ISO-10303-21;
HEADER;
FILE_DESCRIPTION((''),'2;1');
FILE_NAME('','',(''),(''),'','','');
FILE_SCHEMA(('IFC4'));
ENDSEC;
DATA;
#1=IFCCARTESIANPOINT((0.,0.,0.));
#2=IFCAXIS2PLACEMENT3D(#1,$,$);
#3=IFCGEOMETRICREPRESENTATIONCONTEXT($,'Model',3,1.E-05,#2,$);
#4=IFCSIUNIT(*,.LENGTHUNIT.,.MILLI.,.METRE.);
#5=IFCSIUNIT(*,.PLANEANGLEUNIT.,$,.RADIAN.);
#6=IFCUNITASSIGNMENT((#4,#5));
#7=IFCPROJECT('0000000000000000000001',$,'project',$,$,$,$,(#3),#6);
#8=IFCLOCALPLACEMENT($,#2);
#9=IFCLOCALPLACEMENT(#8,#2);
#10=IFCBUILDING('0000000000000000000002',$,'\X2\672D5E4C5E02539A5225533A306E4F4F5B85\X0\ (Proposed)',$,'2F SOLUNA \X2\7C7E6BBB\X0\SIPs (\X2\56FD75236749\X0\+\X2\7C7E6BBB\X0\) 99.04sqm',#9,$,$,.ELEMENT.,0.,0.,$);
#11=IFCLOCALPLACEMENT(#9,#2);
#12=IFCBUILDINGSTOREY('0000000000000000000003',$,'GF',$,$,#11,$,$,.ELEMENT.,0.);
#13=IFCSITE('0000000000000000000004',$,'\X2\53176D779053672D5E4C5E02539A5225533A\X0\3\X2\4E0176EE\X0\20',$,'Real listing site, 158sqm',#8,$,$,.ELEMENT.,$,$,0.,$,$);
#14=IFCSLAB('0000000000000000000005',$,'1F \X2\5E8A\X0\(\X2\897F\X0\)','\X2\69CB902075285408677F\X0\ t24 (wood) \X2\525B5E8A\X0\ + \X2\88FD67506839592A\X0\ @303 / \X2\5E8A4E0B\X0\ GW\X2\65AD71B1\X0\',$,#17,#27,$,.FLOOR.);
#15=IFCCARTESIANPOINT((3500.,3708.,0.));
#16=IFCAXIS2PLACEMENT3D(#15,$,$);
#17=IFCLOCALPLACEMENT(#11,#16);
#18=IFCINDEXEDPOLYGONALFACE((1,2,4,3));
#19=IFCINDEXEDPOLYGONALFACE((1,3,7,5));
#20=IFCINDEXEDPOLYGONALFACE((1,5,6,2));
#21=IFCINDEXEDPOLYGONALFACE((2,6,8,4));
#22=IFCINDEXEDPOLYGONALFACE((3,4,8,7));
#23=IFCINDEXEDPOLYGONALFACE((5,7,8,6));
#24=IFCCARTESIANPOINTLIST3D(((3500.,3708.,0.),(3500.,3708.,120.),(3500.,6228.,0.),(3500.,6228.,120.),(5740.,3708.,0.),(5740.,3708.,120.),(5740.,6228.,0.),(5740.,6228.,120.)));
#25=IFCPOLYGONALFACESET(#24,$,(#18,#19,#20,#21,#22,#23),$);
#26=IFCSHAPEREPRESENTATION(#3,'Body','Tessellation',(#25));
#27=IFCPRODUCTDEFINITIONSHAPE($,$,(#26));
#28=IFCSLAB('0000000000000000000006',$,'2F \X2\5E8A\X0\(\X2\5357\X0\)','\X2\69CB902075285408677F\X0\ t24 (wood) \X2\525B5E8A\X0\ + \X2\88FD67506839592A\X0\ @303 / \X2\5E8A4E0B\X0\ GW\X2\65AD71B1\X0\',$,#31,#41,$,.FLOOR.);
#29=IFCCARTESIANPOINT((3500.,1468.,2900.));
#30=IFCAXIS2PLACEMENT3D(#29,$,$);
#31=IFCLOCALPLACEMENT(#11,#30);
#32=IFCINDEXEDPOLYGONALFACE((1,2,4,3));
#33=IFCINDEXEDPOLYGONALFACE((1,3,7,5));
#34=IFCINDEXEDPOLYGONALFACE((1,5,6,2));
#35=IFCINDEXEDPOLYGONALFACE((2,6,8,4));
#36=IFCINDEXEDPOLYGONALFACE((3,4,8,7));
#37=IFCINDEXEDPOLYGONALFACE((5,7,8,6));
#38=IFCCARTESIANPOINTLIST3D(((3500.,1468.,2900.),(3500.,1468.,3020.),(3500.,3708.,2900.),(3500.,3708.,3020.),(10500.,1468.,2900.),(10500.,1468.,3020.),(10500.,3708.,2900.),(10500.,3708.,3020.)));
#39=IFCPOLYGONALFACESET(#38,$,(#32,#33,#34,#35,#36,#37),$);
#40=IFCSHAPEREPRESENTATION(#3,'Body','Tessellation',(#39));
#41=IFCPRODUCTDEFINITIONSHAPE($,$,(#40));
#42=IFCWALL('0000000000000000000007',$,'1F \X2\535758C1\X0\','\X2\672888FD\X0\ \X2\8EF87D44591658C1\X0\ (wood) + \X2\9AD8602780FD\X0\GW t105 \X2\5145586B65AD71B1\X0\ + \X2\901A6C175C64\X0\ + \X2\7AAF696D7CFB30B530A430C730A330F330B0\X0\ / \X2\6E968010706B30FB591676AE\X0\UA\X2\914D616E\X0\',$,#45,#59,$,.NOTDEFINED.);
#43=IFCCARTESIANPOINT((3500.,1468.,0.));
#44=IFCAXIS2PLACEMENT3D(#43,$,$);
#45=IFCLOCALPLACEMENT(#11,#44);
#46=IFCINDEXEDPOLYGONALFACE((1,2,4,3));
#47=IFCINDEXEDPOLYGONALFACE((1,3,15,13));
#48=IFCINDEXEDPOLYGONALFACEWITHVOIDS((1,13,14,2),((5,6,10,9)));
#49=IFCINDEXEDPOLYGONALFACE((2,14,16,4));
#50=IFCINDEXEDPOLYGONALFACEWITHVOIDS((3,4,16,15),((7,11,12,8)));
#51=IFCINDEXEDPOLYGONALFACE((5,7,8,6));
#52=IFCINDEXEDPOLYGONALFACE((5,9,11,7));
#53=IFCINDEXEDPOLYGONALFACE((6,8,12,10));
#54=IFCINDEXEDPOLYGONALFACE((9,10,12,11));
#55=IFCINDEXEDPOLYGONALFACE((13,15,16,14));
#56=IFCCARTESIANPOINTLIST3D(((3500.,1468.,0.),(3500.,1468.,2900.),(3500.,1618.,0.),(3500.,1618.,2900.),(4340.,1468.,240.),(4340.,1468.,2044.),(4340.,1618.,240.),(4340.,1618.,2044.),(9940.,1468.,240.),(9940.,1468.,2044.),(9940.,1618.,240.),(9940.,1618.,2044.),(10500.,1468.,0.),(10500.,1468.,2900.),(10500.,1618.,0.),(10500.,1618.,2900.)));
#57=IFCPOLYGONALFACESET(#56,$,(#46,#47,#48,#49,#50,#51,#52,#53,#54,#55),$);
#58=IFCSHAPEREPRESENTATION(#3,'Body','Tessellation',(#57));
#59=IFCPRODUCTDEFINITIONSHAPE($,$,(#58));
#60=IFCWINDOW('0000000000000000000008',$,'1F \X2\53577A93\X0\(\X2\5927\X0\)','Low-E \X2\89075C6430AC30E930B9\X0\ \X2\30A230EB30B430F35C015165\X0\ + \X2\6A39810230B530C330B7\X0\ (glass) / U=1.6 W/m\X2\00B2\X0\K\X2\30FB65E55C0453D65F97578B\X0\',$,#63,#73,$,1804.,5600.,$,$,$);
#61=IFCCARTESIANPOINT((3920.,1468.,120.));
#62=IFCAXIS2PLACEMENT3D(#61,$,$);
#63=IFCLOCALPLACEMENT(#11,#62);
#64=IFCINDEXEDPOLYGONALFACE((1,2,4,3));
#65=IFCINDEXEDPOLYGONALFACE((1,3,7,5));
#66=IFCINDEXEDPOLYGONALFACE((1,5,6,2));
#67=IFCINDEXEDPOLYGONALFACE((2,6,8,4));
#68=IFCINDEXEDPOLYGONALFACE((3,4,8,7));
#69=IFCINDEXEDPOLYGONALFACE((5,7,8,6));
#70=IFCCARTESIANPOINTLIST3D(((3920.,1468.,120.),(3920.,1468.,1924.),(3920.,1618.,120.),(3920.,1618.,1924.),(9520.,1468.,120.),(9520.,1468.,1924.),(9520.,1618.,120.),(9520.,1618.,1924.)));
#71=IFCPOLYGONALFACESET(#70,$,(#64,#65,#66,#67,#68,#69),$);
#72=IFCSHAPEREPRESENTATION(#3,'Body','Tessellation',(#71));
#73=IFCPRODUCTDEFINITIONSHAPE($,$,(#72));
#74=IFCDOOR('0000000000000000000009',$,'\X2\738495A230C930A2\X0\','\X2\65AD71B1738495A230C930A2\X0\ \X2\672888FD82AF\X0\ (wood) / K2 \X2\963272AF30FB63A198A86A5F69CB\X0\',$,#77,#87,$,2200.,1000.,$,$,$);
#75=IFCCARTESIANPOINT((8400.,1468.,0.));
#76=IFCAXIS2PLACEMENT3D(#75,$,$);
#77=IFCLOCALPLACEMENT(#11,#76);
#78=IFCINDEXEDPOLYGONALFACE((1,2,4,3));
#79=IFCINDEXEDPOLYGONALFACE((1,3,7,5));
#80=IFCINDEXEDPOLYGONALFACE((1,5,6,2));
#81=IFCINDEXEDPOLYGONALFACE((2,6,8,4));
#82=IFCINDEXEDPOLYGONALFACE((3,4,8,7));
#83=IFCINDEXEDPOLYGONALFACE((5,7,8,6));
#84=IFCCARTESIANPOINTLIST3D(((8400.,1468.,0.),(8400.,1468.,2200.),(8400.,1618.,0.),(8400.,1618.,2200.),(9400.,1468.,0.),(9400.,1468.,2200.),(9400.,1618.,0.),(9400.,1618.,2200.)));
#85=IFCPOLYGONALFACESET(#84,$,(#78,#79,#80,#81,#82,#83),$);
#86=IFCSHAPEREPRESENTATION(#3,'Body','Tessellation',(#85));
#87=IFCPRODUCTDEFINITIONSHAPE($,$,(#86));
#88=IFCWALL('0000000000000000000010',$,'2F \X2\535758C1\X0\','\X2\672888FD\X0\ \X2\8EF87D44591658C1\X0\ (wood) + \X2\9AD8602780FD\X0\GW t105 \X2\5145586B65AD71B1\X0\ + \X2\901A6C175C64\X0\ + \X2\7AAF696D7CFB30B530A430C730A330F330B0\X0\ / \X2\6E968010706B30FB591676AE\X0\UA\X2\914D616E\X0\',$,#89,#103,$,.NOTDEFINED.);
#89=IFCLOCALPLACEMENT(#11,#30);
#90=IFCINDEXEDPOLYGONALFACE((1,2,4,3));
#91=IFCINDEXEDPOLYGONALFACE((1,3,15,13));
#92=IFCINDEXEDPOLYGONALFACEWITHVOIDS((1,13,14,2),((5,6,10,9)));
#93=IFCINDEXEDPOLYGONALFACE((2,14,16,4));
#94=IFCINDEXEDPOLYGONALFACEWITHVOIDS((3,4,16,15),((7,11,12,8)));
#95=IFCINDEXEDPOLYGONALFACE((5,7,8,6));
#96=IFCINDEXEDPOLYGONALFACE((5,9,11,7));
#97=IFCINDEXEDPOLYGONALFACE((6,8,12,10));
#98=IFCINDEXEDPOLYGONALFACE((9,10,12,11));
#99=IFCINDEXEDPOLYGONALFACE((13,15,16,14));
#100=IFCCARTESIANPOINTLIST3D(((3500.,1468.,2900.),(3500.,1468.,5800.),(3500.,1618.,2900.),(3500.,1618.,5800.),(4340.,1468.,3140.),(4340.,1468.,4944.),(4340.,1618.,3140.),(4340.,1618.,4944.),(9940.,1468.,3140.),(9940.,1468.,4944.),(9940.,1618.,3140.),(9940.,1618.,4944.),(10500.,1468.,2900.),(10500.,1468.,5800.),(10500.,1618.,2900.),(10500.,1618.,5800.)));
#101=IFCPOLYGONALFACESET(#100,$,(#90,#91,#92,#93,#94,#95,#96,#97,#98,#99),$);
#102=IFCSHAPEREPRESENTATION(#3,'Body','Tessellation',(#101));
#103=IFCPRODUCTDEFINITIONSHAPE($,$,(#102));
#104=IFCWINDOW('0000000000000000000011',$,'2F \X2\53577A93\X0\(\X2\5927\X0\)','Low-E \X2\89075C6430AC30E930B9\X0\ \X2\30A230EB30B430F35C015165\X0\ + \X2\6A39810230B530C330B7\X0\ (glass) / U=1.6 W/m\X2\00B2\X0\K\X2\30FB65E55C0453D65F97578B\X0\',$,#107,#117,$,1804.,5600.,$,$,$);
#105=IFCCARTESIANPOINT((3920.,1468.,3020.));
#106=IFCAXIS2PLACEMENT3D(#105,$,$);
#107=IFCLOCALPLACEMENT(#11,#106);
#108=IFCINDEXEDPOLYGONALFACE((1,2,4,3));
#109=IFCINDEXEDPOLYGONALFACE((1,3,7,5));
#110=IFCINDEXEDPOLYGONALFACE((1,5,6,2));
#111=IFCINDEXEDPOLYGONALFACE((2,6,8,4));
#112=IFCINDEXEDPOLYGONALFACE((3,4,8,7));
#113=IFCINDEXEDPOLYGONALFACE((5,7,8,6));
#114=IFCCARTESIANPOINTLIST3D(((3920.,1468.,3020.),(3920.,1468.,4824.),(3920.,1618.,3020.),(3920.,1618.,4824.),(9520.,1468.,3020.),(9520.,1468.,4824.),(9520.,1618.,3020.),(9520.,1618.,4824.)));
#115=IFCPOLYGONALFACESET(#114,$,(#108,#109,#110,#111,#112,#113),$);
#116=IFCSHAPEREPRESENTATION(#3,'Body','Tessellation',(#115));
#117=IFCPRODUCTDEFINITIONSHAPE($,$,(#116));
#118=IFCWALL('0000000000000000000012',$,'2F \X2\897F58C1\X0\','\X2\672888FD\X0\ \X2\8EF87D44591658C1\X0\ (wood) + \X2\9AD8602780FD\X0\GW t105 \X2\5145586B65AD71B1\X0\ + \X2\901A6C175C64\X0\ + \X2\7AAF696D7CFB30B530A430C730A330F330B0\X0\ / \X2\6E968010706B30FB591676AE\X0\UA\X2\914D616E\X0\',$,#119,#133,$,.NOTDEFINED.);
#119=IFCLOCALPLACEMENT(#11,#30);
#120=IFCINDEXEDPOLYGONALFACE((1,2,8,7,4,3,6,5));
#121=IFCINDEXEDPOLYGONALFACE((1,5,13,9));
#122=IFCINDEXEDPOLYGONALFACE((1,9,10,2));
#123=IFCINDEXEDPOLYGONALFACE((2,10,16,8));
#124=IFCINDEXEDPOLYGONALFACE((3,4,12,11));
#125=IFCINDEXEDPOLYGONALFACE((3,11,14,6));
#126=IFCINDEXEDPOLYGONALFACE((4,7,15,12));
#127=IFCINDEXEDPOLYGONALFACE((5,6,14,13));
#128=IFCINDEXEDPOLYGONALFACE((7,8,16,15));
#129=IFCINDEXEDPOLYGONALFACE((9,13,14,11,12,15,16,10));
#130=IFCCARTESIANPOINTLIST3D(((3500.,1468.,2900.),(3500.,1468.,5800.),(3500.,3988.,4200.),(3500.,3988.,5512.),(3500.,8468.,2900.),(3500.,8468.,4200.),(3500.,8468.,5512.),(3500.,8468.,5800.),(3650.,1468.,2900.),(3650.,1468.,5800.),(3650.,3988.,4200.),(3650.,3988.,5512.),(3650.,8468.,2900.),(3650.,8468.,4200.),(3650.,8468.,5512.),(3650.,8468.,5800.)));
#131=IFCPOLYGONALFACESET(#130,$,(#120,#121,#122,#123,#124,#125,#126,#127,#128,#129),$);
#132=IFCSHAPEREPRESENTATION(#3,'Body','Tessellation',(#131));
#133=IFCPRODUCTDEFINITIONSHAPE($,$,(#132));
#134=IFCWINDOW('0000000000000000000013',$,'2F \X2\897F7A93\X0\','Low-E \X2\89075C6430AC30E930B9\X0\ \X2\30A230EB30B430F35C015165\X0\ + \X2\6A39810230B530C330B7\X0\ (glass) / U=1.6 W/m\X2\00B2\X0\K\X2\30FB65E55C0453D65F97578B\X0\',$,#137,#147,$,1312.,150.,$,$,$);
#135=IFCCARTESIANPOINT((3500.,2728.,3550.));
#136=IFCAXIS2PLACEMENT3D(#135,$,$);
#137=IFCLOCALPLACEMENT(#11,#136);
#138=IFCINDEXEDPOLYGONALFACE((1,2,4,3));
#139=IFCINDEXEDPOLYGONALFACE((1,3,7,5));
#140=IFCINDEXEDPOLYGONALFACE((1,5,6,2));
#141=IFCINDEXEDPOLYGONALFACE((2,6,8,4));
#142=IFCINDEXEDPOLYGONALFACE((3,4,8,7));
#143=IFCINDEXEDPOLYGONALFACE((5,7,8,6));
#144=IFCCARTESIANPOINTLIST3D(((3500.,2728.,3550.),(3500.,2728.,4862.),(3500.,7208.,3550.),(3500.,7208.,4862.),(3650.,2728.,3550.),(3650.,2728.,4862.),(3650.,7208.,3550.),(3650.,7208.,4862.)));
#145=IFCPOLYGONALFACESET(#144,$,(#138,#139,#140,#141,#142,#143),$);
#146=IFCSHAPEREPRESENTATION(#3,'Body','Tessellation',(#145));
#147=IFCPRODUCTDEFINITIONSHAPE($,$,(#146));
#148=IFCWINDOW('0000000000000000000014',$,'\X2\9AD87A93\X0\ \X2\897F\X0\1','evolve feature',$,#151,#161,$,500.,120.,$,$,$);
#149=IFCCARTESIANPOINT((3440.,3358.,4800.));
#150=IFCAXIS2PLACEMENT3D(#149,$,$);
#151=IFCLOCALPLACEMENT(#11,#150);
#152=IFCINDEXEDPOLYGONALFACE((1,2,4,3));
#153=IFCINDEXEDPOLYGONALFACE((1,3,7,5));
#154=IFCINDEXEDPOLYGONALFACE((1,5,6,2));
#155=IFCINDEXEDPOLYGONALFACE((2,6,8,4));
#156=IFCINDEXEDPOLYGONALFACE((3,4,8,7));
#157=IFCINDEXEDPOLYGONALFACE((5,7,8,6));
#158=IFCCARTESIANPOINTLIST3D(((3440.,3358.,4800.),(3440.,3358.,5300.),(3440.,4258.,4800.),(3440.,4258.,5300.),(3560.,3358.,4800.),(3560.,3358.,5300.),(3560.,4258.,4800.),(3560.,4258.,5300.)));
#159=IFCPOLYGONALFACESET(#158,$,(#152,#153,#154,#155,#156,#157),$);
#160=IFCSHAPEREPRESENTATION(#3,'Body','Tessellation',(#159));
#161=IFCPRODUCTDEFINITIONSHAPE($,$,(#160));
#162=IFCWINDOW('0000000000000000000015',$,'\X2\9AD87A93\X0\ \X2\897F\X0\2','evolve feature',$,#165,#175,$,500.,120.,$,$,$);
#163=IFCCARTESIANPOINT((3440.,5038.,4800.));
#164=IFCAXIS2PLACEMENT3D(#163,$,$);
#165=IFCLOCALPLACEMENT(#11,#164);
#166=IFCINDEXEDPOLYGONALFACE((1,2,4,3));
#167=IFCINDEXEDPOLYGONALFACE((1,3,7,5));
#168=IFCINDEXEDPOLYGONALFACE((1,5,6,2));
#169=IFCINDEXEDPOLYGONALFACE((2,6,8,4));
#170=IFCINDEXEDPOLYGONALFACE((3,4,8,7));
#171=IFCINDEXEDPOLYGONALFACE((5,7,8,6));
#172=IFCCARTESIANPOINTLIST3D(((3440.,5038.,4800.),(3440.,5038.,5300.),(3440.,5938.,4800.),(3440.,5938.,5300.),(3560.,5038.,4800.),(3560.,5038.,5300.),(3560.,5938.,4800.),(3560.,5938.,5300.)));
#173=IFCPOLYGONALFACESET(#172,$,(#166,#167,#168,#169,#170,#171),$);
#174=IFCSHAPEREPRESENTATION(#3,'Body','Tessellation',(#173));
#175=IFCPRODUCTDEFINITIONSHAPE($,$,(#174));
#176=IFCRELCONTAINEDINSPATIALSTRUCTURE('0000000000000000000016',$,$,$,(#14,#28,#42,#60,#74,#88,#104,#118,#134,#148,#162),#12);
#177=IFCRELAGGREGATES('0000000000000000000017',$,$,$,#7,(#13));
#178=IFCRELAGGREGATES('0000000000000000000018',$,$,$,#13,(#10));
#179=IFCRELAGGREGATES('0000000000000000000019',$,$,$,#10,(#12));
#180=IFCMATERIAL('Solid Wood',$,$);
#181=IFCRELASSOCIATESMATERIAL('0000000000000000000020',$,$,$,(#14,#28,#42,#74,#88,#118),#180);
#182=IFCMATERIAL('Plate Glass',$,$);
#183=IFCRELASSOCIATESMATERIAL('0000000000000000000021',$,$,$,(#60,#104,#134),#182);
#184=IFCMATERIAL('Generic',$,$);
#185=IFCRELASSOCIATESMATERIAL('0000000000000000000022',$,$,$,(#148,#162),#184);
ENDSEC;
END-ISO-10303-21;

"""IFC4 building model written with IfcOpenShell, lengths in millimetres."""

from ifc_helpers import new_model, si_unit, frame, frame_2d, origin, place, context, project, spatial, rectangle, extrude, material, element, fill, save


model = new_model("IFC4")

# Units and contexts
model_context = context("Model", 3, precision=1e-05, world=origin())
ifc_project = project(units=[si_unit("LENGTHUNIT", "METRE", prefix="MILLI"), si_unit("PLANEANGLEUNIT", "RADIAN")], contexts=[model_context])

# Site, building, storey
site_placement = place(None, origin())
site = spatial("IfcSite", under=ifc_project, at=site_placement, Name="北海道札幌市厚別区3丁目20", ObjectType="Real listing site, 158sqm", CompositionType="ELEMENT", RefElevation=0.0)
building_placement = place(site_placement, origin())
building = spatial("IfcBuilding", under=site, at=building_placement, Name="札幌市厚別区の住宅 (Proposed)", ObjectType="2F SOLUNA 籾殻SIPs (国産杉+籾殻) 99.04sqm", CompositionType="ELEMENT", ElevationOfRefHeight=0.0, ElevationOfTerrain=0.0)
storey_placement = place(building_placement, origin())
storey = spatial("IfcBuildingStorey", under=building, at=storey_placement, Name="GF", CompositionType="ELEMENT", Elevation=0.0)

# Slabs
ifc_material_1 = material(Name="Solid Wood")
slab_1_placement = place(storey_placement, frame((3500.0, 3708.0, 0.0)))
element("IfcSlab", 1, at=slab_1_placement, inside=storey, material=ifc_material_1, Name="1F 床(西)", Description="構造用合板 t24 (wood) 剛床 + 製材根太 @303 / 床下 GW断熱", PredefinedType="FLOOR", context=model_context, shape_type="SweptSolid", body=[
    extrude(rectangle(XDim=2240.0, YDim=2520.0, at=frame_2d((1120.0, 1260.0))), frame((3500.0, 3708.0, 0.0)), (0.0, 0.0, 1.0), 120.0),
])
slab_2_placement = place(storey_placement, frame((3500.0, 1468.0, 2900.0)))
element("IfcSlab", 2, at=slab_2_placement, inside=storey, material=ifc_material_1, Name="2F 床(南)", Description="構造用合板 t24 (wood) 剛床 + 製材根太 @303 / 床下 GW断熱", PredefinedType="FLOOR", context=model_context, shape_type="SweptSolid", body=[
    extrude(rectangle(XDim=7000.0, YDim=2240.0, at=frame_2d((3500.0, 1120.0))), frame((3500.0, 1468.0, 2900.0)), (0.0, 0.0, 1.0), 120.0),
])
ifc_material_2 = material(Name="Generic")

# Wall, openings, window, door
wall_1_placement = place(storey_placement, frame((3500.0, 1468.0, 0.0)))
wall_1 = element("IfcWall", 3, at=wall_1_placement, inside=storey, material=ifc_material_1, Name="1F 南壁", Description="木製 軸組外壁 (wood) + 高性能GW t105 充填断熱 + 通気層 + 窯業系サイディング / 準耐火・外皮UA配慮", PredefinedType="NOTDEFINED", context=model_context, shape_type="SweptSolid", body=[
    extrude(rectangle(XDim=7000.0, YDim=150.0, at=frame_2d((3500.0, 75.0))), frame((3500.0, 1468.0, 0.0)), (0.0, 0.0, 1.0), 2900.0),
])
opening_1_placement = place(storey_placement, frame((3920.0, 1468.0, 120.0)))
opening_1 = element("IfcOpeningElement", 4, at=opening_1_placement, cuts=wall_1, PredefinedType="NOTDEFINED", context=model_context, shape_type="SweptSolid", body=[
    extrude(rectangle(XDim=5600.0, YDim=150.0, at=frame_2d((2800.0, 75.0))), frame((3920.0, 1468.0, 120.0)), (0.0, 0.0, 1.0), 1804.0),
])
opening_2_placement = place(storey_placement, frame((8400.0, 1468.0, 0.0)))
opening_2 = element("IfcOpeningElement", 5, at=opening_2_placement, cuts=wall_1, PredefinedType="NOTDEFINED", context=model_context, shape_type="SweptSolid", body=[
    extrude(rectangle(XDim=1000.0, YDim=150.0, at=frame_2d((500.0, 75.0))), frame((8400.0, 1468.0, 0.0)), (0.0, 0.0, 1.0), 2200.0),
])
ifc_material_3 = material(Name="Plate Glass")
window_1_placement = place(storey_placement, frame((3920.0, 1468.0, 120.0)))
window_1 = element("IfcWindow", 6, at=window_1_placement, inside=storey, material=ifc_material_3, Name="1F 南窓(大)", Description="Low-E 複層ガラス アルゴン封入 + 樹脂サッシ (glass) / U=1.6 W/m²K・日射取得型", OverallHeight=1804.0, OverallWidth=5600.0, context=model_context, shape_type="SweptSolid", body=[
    extrude(rectangle(XDim=5600.0, YDim=150.0, at=frame_2d((2800.0, 75.0))), frame((3920.0, 1468.0, 120.0)), (0.0, 0.0, 1.0), 1804.0),
])
fill(opening_1, window_1)
door_placement = place(storey_placement, frame((8400.0, 1468.0, 0.0)))
door = element("IfcDoor", 7, at=door_placement, inside=storey, material=ifc_material_1, Name="玄関ドア", Description="断熱玄関ドア 木製芯 (wood) / K2 防犯・採風機構", OverallHeight=2200.0, OverallWidth=1000.0, context=model_context, shape_type="SweptSolid", body=[
    extrude(rectangle(XDim=1000.0, YDim=150.0, at=frame_2d((500.0, 75.0))), frame((8400.0, 1468.0, 0.0)), (0.0, 0.0, 1.0), 2200.0),
])
fill(opening_2, door)

# Wall, opening, window
wall_2_placement = place(storey_placement, frame((3500.0, 1468.0, 2900.0)))
wall_2 = element("IfcWall", 8, at=wall_2_placement, inside=storey, material=ifc_material_1, Name="2F 南壁", Description="木製 軸組外壁 (wood) + 高性能GW t105 充填断熱 + 通気層 + 窯業系サイディング / 準耐火・外皮UA配慮", PredefinedType="NOTDEFINED", context=model_context, shape_type="SweptSolid", body=[
    extrude(rectangle(XDim=7000.0, YDim=150.0, at=frame_2d((3500.0, 75.0))), frame((3500.0, 1468.0, 2900.0)), (0.0, 0.0, 1.0), 2900.0),
])
opening_3_placement = place(storey_placement, frame((3920.0, 1468.0, 3020.0)))
opening_3 = element("IfcOpeningElement", 9, at=opening_3_placement, cuts=wall_2, PredefinedType="NOTDEFINED", context=model_context, shape_type="SweptSolid", body=[
    extrude(rectangle(XDim=5600.0, YDim=150.0, at=frame_2d((2800.0, 75.0))), frame((3920.0, 1468.0, 3020.0)), (0.0, 0.0, 1.0), 1804.0),
])
window_2_placement = place(storey_placement, frame((3920.0, 1468.0, 3020.0)))
window_2 = element("IfcWindow", 10, at=window_2_placement, inside=storey, material=ifc_material_3, Name="2F 南窓(大)", Description="Low-E 複層ガラス アルゴン封入 + 樹脂サッシ (glass) / U=1.6 W/m²K・日射取得型", OverallHeight=1804.0, OverallWidth=5600.0, context=model_context, shape_type="SweptSolid", body=[
    extrude(rectangle(XDim=5600.0, YDim=150.0, at=frame_2d((2800.0, 75.0))), frame((3920.0, 1468.0, 3020.0)), (0.0, 0.0, 1.0), 1804.0),
])
fill(opening_3, window_2)

# Wall, openings, windows
wall_3_placement = place(storey_placement, frame((3500.0, 1468.0, 2900.0)))
wall_3 = element("IfcWall", 11, at=wall_3_placement, inside=storey, material=ifc_material_1, Name="2F 西壁", Description="木製 軸組外壁 (wood) + 高性能GW t105 充填断熱 + 通気層 + 窯業系サイディング / 準耐火・外皮UA配慮", PredefinedType="NOTDEFINED", context=model_context, shape_type="SweptSolid", body=[
    extrude(rectangle(XDim=150.0, YDim=7000.0, at=frame_2d((75.0, 3500.0))), frame((3500.0, 1468.0, 2900.0)), (0.0, 0.0, 1.0), 2900.0),
])
opening_4_placement = place(storey_placement, frame((3500.0, 2728.0, 3550.0)))
opening_4 = element("IfcOpeningElement", 12, at=opening_4_placement, cuts=wall_3, PredefinedType="NOTDEFINED", context=model_context, shape_type="SweptSolid", body=[
    extrude(rectangle(XDim=150.0, YDim=4480.0, at=frame_2d((75.0, 2240.0))), frame((3500.0, 2728.0, 3550.0)), (0.0, 0.0, 1.0), 1312.0),
])
opening_5_placement = place(storey_placement, frame((3440.0, 3358.0, 4800.0)))
opening_5 = element("IfcOpeningElement", 13, at=opening_5_placement, cuts=wall_3, PredefinedType="NOTDEFINED", context=model_context, shape_type="SweptSolid", body=[
    extrude(rectangle(XDim=120.0, YDim=900.0, at=frame_2d((60.0, 450.0))), frame((3440.0, 3358.0, 4800.0)), (0.0, 0.0, 1.0), 500.0),
])
opening_6_placement = place(storey_placement, frame((3440.0, 5038.0, 4800.0)))
opening_6 = element("IfcOpeningElement", 14, at=opening_6_placement, cuts=wall_3, PredefinedType="NOTDEFINED", context=model_context, shape_type="SweptSolid", body=[
    extrude(rectangle(XDim=120.0, YDim=900.0, at=frame_2d((60.0, 450.0))), frame((3440.0, 5038.0, 4800.0)), (0.0, 0.0, 1.0), 500.0),
])
window_3_placement = place(storey_placement, frame((3500.0, 2728.0, 3550.0)))
window_3 = element("IfcWindow", 15, at=window_3_placement, inside=storey, material=ifc_material_3, Name="2F 西窓", Description="Low-E 複層ガラス アルゴン封入 + 樹脂サッシ (glass) / U=1.6 W/m²K・日射取得型", OverallHeight=1312.0, OverallWidth=150.0, context=model_context, shape_type="SweptSolid", body=[
    extrude(rectangle(XDim=150.0, YDim=4480.0, at=frame_2d((75.0, 2240.0))), frame((3500.0, 2728.0, 3550.0)), (0.0, 0.0, 1.0), 1312.0),
])
fill(opening_4, window_3)
window_4_placement = place(storey_placement, frame((3440.0, 3358.0, 4800.0)))
window_4 = element("IfcWindow", 16, at=window_4_placement, inside=storey, material=ifc_material_2, Name="高窓 西1", Description="evolve feature", OverallHeight=500.0, OverallWidth=120.0, context=model_context, shape_type="SweptSolid", body=[
    extrude(rectangle(XDim=120.0, YDim=900.0, at=frame_2d((60.0, 450.0))), frame((3440.0, 3358.0, 4800.0)), (0.0, 0.0, 1.0), 500.0),
])
fill(opening_5, window_4)
window_5_placement = place(storey_placement, frame((3440.0, 5038.0, 4800.0)))
window_5 = element("IfcWindow", 17, at=window_5_placement, inside=storey, material=ifc_material_2, Name="高窓 西2", Description="evolve feature", OverallHeight=500.0, OverallWidth=120.0, context=model_context, shape_type="SweptSolid", body=[
    extrude(rectangle(XDim=120.0, YDim=900.0, at=frame_2d((60.0, 450.0))), frame((3440.0, 5038.0, 4800.0)), (0.0, 0.0, 1.0), 500.0),
])
fill(opening_6, window_5)

save(model, "model.ifc")
